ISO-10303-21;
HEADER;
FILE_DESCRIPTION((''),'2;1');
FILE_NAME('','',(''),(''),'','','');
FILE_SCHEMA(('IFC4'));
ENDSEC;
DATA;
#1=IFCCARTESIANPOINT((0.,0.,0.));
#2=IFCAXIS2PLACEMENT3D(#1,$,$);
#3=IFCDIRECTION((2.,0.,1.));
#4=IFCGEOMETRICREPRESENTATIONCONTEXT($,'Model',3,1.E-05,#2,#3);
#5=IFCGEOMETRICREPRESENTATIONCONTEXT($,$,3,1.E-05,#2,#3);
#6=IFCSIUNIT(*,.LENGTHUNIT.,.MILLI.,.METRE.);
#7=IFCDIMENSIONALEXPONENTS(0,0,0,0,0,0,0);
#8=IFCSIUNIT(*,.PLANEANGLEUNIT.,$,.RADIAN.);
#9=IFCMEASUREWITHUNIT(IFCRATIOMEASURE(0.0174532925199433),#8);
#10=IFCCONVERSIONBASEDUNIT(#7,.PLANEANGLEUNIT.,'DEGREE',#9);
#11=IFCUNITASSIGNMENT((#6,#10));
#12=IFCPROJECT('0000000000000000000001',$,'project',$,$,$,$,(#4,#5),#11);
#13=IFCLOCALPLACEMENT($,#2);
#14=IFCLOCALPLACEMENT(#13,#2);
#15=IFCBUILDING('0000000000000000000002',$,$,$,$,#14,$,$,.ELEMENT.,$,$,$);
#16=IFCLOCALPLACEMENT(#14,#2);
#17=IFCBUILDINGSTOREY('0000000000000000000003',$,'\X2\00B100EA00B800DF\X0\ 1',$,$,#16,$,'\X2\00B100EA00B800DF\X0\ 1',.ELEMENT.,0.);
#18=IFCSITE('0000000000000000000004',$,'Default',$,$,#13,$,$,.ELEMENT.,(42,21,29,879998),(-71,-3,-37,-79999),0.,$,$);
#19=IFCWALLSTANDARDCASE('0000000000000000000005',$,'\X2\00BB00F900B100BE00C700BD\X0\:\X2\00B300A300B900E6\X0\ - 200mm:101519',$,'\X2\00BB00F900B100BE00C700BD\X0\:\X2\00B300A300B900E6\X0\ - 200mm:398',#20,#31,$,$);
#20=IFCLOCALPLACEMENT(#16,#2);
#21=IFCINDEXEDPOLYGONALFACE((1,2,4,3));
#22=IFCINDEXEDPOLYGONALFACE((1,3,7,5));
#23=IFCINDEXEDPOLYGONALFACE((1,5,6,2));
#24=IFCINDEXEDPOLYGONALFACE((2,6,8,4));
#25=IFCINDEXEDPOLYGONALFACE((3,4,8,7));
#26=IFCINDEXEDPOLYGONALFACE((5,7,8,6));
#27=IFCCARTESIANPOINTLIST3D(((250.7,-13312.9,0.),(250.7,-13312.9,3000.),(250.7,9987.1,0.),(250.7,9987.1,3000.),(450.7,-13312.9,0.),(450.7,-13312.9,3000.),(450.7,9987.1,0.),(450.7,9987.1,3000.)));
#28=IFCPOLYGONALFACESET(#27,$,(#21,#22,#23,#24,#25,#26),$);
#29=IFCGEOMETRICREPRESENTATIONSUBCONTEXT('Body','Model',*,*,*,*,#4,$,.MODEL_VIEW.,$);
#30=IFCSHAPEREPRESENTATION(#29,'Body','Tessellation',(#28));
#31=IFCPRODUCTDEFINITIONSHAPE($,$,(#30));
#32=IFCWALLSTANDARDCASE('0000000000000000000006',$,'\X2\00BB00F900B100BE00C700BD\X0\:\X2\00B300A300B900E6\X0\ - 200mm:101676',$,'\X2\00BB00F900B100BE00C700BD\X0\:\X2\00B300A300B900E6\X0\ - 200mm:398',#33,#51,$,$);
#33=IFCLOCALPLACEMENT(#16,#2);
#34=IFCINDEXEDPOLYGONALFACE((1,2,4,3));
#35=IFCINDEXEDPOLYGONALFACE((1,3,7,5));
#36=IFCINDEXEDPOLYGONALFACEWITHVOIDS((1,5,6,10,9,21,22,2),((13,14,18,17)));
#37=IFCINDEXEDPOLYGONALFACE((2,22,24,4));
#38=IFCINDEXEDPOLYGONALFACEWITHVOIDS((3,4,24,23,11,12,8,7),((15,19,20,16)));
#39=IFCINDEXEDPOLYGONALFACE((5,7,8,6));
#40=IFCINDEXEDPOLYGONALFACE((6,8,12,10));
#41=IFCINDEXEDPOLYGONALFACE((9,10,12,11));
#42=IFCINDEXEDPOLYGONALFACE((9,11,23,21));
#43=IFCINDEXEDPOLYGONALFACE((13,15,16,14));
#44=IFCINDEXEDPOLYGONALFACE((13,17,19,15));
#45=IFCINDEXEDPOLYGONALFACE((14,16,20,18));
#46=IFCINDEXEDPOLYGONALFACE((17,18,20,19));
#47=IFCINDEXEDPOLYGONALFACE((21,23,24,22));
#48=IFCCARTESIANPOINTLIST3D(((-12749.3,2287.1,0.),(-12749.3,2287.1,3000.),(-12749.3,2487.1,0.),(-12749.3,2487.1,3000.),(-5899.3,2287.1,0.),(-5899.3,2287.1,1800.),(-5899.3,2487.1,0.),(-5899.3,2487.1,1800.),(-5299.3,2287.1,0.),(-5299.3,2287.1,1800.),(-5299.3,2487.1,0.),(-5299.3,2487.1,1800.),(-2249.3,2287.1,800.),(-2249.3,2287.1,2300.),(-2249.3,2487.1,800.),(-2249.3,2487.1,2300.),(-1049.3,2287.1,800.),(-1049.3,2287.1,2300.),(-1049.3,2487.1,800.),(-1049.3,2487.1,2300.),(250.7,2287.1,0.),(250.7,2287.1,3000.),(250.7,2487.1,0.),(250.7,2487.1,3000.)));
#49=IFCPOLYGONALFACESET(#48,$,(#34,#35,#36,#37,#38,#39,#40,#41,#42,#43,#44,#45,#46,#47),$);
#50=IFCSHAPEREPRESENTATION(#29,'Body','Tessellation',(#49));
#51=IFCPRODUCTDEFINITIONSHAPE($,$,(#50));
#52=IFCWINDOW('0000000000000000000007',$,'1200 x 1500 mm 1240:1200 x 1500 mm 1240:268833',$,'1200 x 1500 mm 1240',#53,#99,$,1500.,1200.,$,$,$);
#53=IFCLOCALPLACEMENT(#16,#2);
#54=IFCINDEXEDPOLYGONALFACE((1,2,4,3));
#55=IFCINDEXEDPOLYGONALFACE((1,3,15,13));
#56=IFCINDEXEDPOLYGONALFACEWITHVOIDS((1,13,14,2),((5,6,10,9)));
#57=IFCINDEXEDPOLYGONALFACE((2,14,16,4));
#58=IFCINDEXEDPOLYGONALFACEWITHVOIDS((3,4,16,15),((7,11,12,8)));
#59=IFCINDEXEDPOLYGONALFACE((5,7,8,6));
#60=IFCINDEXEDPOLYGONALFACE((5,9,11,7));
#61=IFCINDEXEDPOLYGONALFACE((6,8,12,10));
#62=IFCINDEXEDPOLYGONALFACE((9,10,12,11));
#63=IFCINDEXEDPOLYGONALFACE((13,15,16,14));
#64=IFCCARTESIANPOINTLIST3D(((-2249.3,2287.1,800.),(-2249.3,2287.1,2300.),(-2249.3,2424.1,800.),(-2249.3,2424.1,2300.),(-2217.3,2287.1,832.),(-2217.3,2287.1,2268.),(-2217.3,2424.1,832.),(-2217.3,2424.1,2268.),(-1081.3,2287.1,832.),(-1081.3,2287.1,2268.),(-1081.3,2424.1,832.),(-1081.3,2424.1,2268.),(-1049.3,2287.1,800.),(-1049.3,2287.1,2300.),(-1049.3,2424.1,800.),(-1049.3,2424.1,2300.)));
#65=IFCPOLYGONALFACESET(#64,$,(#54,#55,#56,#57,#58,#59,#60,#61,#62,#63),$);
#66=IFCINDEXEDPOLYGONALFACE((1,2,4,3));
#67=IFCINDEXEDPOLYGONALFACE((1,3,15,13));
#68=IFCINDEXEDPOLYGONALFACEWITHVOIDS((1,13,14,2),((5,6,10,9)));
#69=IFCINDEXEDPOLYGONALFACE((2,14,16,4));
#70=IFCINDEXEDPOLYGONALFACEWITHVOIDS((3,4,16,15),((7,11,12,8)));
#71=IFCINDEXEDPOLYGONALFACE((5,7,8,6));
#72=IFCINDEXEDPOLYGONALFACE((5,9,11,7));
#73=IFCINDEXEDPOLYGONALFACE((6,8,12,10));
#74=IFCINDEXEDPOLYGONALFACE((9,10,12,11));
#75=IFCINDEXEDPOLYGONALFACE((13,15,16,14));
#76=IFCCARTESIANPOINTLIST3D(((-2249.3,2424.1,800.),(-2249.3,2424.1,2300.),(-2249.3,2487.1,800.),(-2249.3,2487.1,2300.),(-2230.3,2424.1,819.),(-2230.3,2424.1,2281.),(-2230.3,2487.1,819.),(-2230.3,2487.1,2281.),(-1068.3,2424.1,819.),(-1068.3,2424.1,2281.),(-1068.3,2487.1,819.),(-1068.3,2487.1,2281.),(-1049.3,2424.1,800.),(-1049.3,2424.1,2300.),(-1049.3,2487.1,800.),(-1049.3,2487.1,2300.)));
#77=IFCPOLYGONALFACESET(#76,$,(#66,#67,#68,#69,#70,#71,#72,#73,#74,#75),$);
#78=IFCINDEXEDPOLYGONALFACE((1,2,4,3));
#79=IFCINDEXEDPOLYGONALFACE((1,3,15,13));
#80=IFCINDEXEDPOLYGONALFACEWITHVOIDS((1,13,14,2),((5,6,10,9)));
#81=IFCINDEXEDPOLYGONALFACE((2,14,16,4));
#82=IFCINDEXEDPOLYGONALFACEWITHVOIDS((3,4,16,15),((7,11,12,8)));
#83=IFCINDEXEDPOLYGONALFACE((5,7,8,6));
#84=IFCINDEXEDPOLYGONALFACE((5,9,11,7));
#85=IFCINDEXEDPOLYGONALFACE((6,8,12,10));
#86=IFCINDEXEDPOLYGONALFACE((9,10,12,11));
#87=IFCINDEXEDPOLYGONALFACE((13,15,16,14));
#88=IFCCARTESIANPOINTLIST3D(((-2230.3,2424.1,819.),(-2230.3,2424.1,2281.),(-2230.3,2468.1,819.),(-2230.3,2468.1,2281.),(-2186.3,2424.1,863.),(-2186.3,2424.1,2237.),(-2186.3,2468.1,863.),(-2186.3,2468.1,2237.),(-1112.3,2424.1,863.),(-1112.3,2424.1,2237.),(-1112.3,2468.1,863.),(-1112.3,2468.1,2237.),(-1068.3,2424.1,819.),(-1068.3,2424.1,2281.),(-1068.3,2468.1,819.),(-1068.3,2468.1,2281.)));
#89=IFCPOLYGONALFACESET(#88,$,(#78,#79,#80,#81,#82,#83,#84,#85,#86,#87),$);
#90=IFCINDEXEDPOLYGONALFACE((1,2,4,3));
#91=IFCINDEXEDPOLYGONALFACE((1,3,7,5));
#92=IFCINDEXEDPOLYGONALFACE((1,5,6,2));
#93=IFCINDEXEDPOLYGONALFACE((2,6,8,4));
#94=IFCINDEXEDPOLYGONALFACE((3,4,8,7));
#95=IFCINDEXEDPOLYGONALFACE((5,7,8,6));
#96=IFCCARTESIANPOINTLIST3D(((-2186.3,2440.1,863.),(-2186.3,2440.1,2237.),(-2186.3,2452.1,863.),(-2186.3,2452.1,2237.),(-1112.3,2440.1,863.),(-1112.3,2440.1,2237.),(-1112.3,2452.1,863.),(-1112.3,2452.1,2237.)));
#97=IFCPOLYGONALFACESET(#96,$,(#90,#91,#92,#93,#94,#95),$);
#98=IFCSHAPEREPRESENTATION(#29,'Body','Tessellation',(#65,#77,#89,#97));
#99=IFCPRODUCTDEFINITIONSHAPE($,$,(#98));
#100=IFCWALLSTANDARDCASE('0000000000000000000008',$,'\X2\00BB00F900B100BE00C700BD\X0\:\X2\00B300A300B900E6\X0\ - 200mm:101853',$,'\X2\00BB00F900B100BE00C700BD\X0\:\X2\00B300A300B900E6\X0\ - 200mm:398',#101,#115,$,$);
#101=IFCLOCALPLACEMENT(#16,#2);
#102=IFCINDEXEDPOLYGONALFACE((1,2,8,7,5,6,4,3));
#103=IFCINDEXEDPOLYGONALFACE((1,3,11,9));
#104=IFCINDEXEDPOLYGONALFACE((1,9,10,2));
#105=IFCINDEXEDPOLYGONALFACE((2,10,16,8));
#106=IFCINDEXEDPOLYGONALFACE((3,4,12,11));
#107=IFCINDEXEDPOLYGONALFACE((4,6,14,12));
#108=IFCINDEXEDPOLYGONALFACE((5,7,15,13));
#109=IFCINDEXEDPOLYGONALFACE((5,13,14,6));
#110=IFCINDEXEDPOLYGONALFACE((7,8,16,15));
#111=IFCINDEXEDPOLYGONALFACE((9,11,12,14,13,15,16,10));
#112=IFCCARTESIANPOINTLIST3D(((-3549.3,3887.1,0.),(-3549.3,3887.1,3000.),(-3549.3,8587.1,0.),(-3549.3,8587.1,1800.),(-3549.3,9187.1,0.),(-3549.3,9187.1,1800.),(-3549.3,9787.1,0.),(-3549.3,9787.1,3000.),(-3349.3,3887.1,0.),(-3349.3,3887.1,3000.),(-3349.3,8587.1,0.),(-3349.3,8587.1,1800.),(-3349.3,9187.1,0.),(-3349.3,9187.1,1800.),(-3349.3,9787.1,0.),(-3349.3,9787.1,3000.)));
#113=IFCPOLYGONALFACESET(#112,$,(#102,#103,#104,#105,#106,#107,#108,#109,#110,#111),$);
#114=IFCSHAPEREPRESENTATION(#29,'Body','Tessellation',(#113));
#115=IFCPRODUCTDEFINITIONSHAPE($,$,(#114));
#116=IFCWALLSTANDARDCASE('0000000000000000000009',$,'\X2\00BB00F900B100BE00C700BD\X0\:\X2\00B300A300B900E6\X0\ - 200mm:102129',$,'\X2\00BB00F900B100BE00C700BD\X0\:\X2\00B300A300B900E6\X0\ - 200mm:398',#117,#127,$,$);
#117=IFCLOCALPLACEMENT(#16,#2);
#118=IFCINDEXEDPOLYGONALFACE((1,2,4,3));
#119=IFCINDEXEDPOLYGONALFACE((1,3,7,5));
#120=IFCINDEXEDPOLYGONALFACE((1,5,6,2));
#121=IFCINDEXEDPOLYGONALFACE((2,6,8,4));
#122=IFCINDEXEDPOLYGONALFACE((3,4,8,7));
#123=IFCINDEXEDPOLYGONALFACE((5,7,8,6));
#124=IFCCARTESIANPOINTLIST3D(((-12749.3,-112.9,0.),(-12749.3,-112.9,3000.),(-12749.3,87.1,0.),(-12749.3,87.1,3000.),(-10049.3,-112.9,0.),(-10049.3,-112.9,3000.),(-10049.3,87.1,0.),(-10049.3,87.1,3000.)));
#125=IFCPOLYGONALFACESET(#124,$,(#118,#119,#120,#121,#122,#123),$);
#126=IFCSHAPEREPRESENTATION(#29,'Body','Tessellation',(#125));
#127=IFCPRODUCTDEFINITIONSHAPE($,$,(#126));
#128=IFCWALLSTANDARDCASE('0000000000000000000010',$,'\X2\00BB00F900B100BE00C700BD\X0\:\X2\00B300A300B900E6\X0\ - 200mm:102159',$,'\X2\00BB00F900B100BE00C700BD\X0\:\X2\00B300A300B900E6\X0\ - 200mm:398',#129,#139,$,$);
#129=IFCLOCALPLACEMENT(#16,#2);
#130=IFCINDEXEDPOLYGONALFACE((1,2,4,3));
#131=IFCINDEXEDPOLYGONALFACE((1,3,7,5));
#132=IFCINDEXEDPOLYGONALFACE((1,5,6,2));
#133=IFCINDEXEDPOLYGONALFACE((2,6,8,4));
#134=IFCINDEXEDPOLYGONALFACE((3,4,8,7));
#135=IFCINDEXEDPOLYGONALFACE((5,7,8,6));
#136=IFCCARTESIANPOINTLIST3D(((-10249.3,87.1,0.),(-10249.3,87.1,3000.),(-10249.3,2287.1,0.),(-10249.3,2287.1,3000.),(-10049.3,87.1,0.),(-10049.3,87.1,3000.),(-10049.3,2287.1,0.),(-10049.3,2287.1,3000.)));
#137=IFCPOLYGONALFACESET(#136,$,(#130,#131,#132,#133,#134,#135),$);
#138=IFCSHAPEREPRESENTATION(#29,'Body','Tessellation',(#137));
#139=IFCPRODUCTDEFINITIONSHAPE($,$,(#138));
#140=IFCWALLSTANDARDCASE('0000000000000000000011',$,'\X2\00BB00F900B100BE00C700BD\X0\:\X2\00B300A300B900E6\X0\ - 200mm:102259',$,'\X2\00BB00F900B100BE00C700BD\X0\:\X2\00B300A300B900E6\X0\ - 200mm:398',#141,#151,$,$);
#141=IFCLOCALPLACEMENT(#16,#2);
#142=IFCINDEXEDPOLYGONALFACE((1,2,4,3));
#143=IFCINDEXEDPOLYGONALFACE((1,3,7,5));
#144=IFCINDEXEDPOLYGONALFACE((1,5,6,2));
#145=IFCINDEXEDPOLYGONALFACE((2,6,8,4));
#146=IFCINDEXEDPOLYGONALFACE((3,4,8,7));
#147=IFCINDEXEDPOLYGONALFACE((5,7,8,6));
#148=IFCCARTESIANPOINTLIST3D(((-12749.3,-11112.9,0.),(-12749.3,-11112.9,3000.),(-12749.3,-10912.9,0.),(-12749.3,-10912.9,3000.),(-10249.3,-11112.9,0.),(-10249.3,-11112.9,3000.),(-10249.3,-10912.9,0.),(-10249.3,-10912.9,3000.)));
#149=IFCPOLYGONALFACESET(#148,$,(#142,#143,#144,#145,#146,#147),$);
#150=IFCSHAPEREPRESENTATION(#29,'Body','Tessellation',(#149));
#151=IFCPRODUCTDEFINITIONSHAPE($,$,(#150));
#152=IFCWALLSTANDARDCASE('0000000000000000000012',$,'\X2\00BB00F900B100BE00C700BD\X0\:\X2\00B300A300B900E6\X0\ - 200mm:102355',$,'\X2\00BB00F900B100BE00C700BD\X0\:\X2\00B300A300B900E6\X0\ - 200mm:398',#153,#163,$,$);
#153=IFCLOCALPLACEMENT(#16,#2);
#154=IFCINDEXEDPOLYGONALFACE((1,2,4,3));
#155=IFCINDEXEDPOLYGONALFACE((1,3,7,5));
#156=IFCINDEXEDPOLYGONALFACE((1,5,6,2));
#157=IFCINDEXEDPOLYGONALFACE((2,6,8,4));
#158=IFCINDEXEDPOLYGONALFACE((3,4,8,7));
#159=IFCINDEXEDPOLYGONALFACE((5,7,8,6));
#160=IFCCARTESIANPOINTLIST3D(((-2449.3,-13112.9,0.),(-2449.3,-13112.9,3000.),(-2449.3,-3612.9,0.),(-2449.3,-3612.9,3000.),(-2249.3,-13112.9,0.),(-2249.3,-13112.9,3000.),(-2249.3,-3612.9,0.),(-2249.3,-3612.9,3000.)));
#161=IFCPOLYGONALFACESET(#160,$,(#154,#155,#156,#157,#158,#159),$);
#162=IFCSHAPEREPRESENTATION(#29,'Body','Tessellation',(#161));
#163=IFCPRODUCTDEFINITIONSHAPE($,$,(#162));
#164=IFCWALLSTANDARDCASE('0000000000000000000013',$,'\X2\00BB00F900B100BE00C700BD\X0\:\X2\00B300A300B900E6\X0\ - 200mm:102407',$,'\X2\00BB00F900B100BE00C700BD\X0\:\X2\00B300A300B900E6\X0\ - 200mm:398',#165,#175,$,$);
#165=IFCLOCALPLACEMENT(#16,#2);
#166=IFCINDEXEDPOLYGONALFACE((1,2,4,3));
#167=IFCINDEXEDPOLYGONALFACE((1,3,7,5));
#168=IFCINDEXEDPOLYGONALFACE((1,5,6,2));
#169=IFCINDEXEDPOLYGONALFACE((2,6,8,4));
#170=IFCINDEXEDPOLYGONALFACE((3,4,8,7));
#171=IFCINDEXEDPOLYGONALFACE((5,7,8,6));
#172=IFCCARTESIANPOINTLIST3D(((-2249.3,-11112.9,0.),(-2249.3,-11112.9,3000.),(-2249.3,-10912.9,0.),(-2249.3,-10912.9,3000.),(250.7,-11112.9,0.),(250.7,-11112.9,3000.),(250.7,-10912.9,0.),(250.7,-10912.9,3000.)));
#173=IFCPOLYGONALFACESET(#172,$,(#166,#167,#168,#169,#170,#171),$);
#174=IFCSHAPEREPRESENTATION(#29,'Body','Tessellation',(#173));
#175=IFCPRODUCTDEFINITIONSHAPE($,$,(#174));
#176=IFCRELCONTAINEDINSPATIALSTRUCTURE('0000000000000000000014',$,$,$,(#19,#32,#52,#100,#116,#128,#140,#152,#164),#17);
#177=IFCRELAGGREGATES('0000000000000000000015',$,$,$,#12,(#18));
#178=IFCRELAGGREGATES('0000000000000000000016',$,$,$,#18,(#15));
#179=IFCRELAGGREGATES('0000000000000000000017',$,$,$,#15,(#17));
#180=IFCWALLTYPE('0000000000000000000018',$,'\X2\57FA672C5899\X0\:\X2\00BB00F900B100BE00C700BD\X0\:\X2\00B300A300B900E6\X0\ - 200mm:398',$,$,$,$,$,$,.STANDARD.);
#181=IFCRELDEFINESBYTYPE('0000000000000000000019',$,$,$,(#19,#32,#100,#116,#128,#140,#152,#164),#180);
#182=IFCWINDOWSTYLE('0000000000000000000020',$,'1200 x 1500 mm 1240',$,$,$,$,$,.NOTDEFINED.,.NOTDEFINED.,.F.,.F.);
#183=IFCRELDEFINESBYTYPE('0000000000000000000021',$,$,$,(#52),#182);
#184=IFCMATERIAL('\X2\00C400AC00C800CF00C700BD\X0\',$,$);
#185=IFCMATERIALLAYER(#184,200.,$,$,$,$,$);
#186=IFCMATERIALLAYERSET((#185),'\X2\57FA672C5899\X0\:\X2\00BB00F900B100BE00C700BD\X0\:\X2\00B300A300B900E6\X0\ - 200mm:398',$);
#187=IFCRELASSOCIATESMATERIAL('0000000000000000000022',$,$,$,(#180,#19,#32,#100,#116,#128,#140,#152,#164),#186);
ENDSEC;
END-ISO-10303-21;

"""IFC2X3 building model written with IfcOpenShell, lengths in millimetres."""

from ifc_helpers import new_model, entity, si_unit, converted_unit, direction, frame, frame_2d, origin, origin_2d_with_axis, place, context, subcontext, project, spatial, polyline, rectangle, outline, extrude, source, transform, mapped, material, layer, layer_set, layer_usage, type_object, type_shapes, element, fill, save


model = new_model("IFC2X3")

# Units and contexts
model_context = context("Model", 3, precision=1e-05, world=origin(), true_north=direction((2.0, 0.0, 1.0)))
context_of_model = context(None, 3, precision=1e-05, world=origin(), true_north=direction((2.0, 0.0, 1.0)))
body_context = subcontext(model_context, "Body", "Model", "MODEL_VIEW")
ifc_project = project(units=[si_unit("LENGTHUNIT", "METRE", prefix="MILLI"), converted_unit("PLANEANGLEUNIT", "DEGREE", entity("IfcRatioMeasure", 0.0174532925199433), si_unit("PLANEANGLEUNIT", "RADIAN"), dimensions=[0, 0, 0, 0, 0, 0, 0])], contexts=[model_context, context_of_model])

# Site, building, storey
site_placement = place(None, origin())
site = spatial("IfcSite", under=ifc_project, at=site_placement, Name="Default", CompositionType="ELEMENT", RefLatitude=(42, 21, 29, 879998), RefLongitude=(-71, -3, -37, -79999), RefElevation=0.0)
building_placement = place(site_placement, origin())
building = spatial("IfcBuilding", under=site, at=building_placement, CompositionType="ELEMENT")
storey_placement = place(building_placement, origin())
storey = spatial("IfcBuildingStorey", under=building, at=storey_placement, Name="±ê¸ß 1", LongName="±ê¸ß 1", CompositionType="ELEMENT", Elevation=0.0)

# Shared definitions
ifc_material_1 = material(Name="Ä¬ÈÏÇ½")
ifc_layer_1 = layer(ifc_material_1, 200.0)
ifc_layer_set_1 = layer_set([ifc_layer_1], Name="基本墙:»ù±¾Ç½:³£¹æ - 200mm:398")
wall_type = type_object("IfcWallType", Name="基本墙:»ù±¾Ç½:³£¹æ - 200mm:398", PredefinedType="STANDARD", material=ifc_layer_set_1)
window_style = type_object("IfcWindowStyle", Name="1200 x 1500 mm 1240", ConstructionType="NOTDEFINED", OperationType="NOTDEFINED", ParameterTakesPrecedence=False, Sizeable=False)
shared_shape = source(origin(), body_context, "Body", "SweptSolid", [
    extrude(outline(polyline([(-750.0, -600.0), (750.0, -600.0), (750.0, 600.0), (-750.0, 600.0), (-750.0, -600.0)]), holes=[polyline([(718.0, 568.0), (718.0, -568.0), (-718.0, -568.0), (-718.0, 568.0), (718.0, 568.0)])]), frame((600.0, -202.0, 750.0), z_axis=(0.0, 1.0, 0.0), x_axis=(0.0, 0.0, -1.0)), (0.0, 0.0, 1.0), 137.0),
    extrude(outline(polyline([(-750.0, -600.0), (750.0, -600.0), (750.0, 600.0), (-750.0, 600.0), (-750.0, -600.0)]), holes=[polyline([(731.0, 581.0), (731.0, -581.0), (-731.0, -581.0), (-731.0, 581.0), (731.0, 581.0)])]), frame((600.0, -65.0, 750.0), z_axis=(0.0, 1.0, 0.0), x_axis=(0.0, 0.0, -1.0)), (0.0, 0.0, 1.0), 63.0),
    extrude(outline(polyline([(-731.0, -581.0), (731.0, -581.0), (731.0, 581.0), (-731.0, 581.0), (-731.0, -581.0)]), holes=[polyline([(687.0, 537.0), (687.0, -537.0), (-687.0, -537.0), (-687.0, 537.0), (687.0, 537.0)])]), frame((600.0, -65.0, 750.0), z_axis=(0.0, 1.0, 0.0), x_axis=(0.0, 0.0, -1.0)), (0.0, 0.0, 1.0), 44.0),
    extrude(rectangle(XDim=1074.0, YDim=12.0, at=origin_2d_with_axis()), frame((600.0, -43.0, 63.0)), (0.0, 0.0, 1.0), 1374.0),
])
type_shapes(window_style, [shared_shape])

# Wall
ifc_layer_usage_1 = layer_usage(ifc_layer_set_1, "AXIS2", "NEGATIVE", 100.0)
wall_1_placement = place(storey_placement, frame((350.7, -13312.9, 0.0), z_axis=(0.0, 0.0, 1.0), x_axis=(0.0, 1.0, 0.0)))
element("IfcWallStandardCase", 1, at=wall_1_placement, inside=storey, type_object=wall_type, material=ifc_layer_usage_1, Name="»ù±¾Ç½:³£¹æ - 200mm:101519", ObjectType="»ù±¾Ç½:³£¹æ - 200mm:398", context=body_context, shape_type="SweptSolid", body=[
    extrude(rectangle(XDim=23300.0, YDim=200.0, at=frame_2d((11650.0, 0.0), x_axis=(-1.0, 0.0))), origin(), (0.0, 0.0, 1.0), 3000.0),
])

# Wall, openings, window
ifc_layer_usage_2 = layer_usage(ifc_layer_set_1, "AXIS2", "NEGATIVE", 100.0)
wall_2_placement = place(storey_placement, frame((-12749.3, 2387.1, 0.0)))
wall_2 = element("IfcWallStandardCase", 2, at=wall_2_placement, inside=storey, type_object=wall_type, material=ifc_layer_usage_2, Name="»ù±¾Ç½:³£¹æ - 200mm:101676", ObjectType="»ù±¾Ç½:³£¹æ - 200mm:398", context=body_context, shape_type="SweptSolid", body=[
    extrude(rectangle(XDim=13000.0, YDim=200.0, at=frame_2d((6500.0, 0.0), x_axis=(-1.0, 0.0))), origin(), (0.0, 0.0, 1.0), 3000.0),
])
opening_1_placement = place(wall_2_placement, origin())
element("IfcOpeningElement", 3, at=opening_1_placement, cuts=wall_2, ObjectType="Opening", context=body_context, shape_type="SweptSolid", body=[
    extrude(rectangle(XDim=1800.0, YDim=600.0, at=origin_2d_with_axis()), frame((7150.0, -102.0, 900.0), z_axis=(0.0, 1.0, 0.0), x_axis=(0.0, 0.0, -1.0)), (0.0, 0.0, 1.0), 204.0),
])
opening_2_placement = place(wall_2_placement, origin())
opening_2 = element("IfcOpeningElement", 4, at=opening_2_placement, cuts=wall_2, ObjectType="Opening", context=body_context, shape_type="SweptSolid", body=[
    extrude(rectangle(XDim=1500.0, YDim=1200.0, at=frame_2d((0.0, 0.0), x_axis=(0.0, 1.0))), frame((11100.0, -102.0, 1550.0), z_axis=(0.0, 1.0, 0.0), x_axis=(1.0, 0.0, 0.0)), (0.0, 0.0, 1.0), 204.0),
])
window_1_placement = place(opening_2_placement, frame((10500.0, 102.0, 800.0)))
window_1 = element("IfcWindow", 5, at=window_1_placement, inside=storey, type_object=window_style, Name="1200 x 1500 mm 1240:1200 x 1500 mm 1240:268833", ObjectType="1200 x 1500 mm 1240", OverallHeight=1500.0, OverallWidth=1200.0, context=body_context, shape_type="MappedRepresentation", body=[
    mapped(shared_shape, transform((0.0, 0.0, 0.0), scale=1.0)),
])
fill(opening_2, window_1)

# Wall, opening
ifc_layer_usage_3 = layer_usage(ifc_layer_set_1, "AXIS2", "NEGATIVE", 100.0)
wall_3_placement = place(storey_placement, frame((-3449.3, 3887.1, 0.0), z_axis=(0.0, 0.0, 1.0), x_axis=(0.0, 1.0, 0.0)))
wall_3 = element("IfcWallStandardCase", 6, at=wall_3_placement, inside=storey, type_object=wall_type, material=ifc_layer_usage_3, Name="»ù±¾Ç½:³£¹æ - 200mm:101853", ObjectType="»ù±¾Ç½:³£¹æ - 200mm:398", context=body_context, shape_type="SweptSolid", body=[
    extrude(rectangle(XDim=5900.0, YDim=200.0, at=frame_2d((2950.0, 0.0), x_axis=(-1.0, 0.0))), origin(), (0.0, 0.0, 1.0), 3000.0),
])
opening_3_placement = place(wall_3_placement, origin())
element("IfcOpeningElement", 7, at=opening_3_placement, cuts=wall_3, ObjectType="Opening", context=body_context, shape_type="SweptSolid", body=[
    extrude(rectangle(XDim=1800.0, YDim=600.0, at=origin_2d_with_axis()), frame((5000.0, -102.0, 900.0), z_axis=(0.0, 1.0, 0.0), x_axis=(0.0, 0.0, -1.0)), (0.0, 0.0, 1.0), 204.0),
])

# Walls
ifc_layer_usage_4 = layer_usage(ifc_layer_set_1, "AXIS2", "NEGATIVE", 100.0)
wall_4_placement = place(storey_placement, frame((-12749.3, -12.9, 0.0)))
element("IfcWallStandardCase", 8, at=wall_4_placement, inside=storey, type_object=wall_type, material=ifc_layer_usage_4, Name="»ù±¾Ç½:³£¹æ - 200mm:102129", ObjectType="»ù±¾Ç½:³£¹æ - 200mm:398", context=body_context, shape_type="SweptSolid", body=[
    extrude(rectangle(XDim=2700.0, YDim=200.0, at=frame_2d((1350.0, 0.0), x_axis=(-1.0, 0.0))), origin(), (0.0, 0.0, 1.0), 3000.0),
])
ifc_layer_usage_5 = layer_usage(ifc_layer_set_1, "AXIS2", "NEGATIVE", 100.0)
wall_5_placement = place(storey_placement, frame((-10149.3, 87.1, 0.0), z_axis=(0.0, 0.0, 1.0), x_axis=(0.0, 1.0, 0.0)))
element("IfcWallStandardCase", 9, at=wall_5_placement, inside=storey, type_object=wall_type, material=ifc_layer_usage_5, Name="»ù±¾Ç½:³£¹æ - 200mm:102159", ObjectType="»ù±¾Ç½:³£¹æ - 200mm:398", context=body_context, shape_type="SweptSolid", body=[
    extrude(rectangle(XDim=2200.0, YDim=200.0, at=frame_2d((1100.0, 0.0), x_axis=(-1.0, 0.0))), origin(), (0.0, 0.0, 1.0), 3000.0),
])

# Walls
ifc_layer_usage_6 = layer_usage(ifc_layer_set_1, "AXIS2", "NEGATIVE", 100.0)
wall_6_placement = place(storey_placement, frame((-12749.3, -11012.9, 0.0)))
element("IfcWallStandardCase", 10, at=wall_6_placement, inside=storey, type_object=wall_type, material=ifc_layer_usage_6, Name="»ù±¾Ç½:³£¹æ - 200mm:102259", ObjectType="»ù±¾Ç½:³£¹æ - 200mm:398", context=body_context, shape_type="SweptSolid", body=[
    extrude(rectangle(XDim=2500.0, YDim=200.0, at=frame_2d((1250.0, 0.0), x_axis=(-1.0, 0.0))), origin(), (0.0, 0.0, 1.0), 3000.0),
])
ifc_layer_usage_7 = layer_usage(ifc_layer_set_1, "AXIS2", "NEGATIVE", 100.0)
wall_7_placement = place(storey_placement, frame((-2349.3, -3612.9, 0.0), z_axis=(0.0, 0.0, 1.0), x_axis=(0.0, -1.0, 0.0)))
element("IfcWallStandardCase", 11, at=wall_7_placement, inside=storey, type_object=wall_type, material=ifc_layer_usage_7, Name="»ù±¾Ç½:³£¹æ - 200mm:102355", ObjectType="»ù±¾Ç½:³£¹æ - 200mm:398", context=body_context, shape_type="SweptSolid", body=[
    extrude(rectangle(XDim=9500.0, YDim=200.0, at=frame_2d((4750.0, 0.0), x_axis=(-1.0, 0.0))), origin(), (0.0, 0.0, 1.0), 3000.0),
])
ifc_layer_usage_8 = layer_usage(ifc_layer_set_1, "AXIS2", "NEGATIVE", 100.0)
wall_8_placement = place(storey_placement, frame((-2249.3, -11012.9, 0.0)))
element("IfcWallStandardCase", 12, at=wall_8_placement, inside=storey, type_object=wall_type, material=ifc_layer_usage_8, Name="»ù±¾Ç½:³£¹æ - 200mm:102407", ObjectType="»ù±¾Ç½:³£¹æ - 200mm:398", context=body_context, shape_type="SweptSolid", body=[
    extrude(rectangle(XDim=2500.0, YDim=200.0, at=frame_2d((1250.0, 0.0), x_axis=(-1.0, 0.0))), origin(), (0.0, 0.0, 1.0), 3000.0),
])

save(model, "model.ifc")
